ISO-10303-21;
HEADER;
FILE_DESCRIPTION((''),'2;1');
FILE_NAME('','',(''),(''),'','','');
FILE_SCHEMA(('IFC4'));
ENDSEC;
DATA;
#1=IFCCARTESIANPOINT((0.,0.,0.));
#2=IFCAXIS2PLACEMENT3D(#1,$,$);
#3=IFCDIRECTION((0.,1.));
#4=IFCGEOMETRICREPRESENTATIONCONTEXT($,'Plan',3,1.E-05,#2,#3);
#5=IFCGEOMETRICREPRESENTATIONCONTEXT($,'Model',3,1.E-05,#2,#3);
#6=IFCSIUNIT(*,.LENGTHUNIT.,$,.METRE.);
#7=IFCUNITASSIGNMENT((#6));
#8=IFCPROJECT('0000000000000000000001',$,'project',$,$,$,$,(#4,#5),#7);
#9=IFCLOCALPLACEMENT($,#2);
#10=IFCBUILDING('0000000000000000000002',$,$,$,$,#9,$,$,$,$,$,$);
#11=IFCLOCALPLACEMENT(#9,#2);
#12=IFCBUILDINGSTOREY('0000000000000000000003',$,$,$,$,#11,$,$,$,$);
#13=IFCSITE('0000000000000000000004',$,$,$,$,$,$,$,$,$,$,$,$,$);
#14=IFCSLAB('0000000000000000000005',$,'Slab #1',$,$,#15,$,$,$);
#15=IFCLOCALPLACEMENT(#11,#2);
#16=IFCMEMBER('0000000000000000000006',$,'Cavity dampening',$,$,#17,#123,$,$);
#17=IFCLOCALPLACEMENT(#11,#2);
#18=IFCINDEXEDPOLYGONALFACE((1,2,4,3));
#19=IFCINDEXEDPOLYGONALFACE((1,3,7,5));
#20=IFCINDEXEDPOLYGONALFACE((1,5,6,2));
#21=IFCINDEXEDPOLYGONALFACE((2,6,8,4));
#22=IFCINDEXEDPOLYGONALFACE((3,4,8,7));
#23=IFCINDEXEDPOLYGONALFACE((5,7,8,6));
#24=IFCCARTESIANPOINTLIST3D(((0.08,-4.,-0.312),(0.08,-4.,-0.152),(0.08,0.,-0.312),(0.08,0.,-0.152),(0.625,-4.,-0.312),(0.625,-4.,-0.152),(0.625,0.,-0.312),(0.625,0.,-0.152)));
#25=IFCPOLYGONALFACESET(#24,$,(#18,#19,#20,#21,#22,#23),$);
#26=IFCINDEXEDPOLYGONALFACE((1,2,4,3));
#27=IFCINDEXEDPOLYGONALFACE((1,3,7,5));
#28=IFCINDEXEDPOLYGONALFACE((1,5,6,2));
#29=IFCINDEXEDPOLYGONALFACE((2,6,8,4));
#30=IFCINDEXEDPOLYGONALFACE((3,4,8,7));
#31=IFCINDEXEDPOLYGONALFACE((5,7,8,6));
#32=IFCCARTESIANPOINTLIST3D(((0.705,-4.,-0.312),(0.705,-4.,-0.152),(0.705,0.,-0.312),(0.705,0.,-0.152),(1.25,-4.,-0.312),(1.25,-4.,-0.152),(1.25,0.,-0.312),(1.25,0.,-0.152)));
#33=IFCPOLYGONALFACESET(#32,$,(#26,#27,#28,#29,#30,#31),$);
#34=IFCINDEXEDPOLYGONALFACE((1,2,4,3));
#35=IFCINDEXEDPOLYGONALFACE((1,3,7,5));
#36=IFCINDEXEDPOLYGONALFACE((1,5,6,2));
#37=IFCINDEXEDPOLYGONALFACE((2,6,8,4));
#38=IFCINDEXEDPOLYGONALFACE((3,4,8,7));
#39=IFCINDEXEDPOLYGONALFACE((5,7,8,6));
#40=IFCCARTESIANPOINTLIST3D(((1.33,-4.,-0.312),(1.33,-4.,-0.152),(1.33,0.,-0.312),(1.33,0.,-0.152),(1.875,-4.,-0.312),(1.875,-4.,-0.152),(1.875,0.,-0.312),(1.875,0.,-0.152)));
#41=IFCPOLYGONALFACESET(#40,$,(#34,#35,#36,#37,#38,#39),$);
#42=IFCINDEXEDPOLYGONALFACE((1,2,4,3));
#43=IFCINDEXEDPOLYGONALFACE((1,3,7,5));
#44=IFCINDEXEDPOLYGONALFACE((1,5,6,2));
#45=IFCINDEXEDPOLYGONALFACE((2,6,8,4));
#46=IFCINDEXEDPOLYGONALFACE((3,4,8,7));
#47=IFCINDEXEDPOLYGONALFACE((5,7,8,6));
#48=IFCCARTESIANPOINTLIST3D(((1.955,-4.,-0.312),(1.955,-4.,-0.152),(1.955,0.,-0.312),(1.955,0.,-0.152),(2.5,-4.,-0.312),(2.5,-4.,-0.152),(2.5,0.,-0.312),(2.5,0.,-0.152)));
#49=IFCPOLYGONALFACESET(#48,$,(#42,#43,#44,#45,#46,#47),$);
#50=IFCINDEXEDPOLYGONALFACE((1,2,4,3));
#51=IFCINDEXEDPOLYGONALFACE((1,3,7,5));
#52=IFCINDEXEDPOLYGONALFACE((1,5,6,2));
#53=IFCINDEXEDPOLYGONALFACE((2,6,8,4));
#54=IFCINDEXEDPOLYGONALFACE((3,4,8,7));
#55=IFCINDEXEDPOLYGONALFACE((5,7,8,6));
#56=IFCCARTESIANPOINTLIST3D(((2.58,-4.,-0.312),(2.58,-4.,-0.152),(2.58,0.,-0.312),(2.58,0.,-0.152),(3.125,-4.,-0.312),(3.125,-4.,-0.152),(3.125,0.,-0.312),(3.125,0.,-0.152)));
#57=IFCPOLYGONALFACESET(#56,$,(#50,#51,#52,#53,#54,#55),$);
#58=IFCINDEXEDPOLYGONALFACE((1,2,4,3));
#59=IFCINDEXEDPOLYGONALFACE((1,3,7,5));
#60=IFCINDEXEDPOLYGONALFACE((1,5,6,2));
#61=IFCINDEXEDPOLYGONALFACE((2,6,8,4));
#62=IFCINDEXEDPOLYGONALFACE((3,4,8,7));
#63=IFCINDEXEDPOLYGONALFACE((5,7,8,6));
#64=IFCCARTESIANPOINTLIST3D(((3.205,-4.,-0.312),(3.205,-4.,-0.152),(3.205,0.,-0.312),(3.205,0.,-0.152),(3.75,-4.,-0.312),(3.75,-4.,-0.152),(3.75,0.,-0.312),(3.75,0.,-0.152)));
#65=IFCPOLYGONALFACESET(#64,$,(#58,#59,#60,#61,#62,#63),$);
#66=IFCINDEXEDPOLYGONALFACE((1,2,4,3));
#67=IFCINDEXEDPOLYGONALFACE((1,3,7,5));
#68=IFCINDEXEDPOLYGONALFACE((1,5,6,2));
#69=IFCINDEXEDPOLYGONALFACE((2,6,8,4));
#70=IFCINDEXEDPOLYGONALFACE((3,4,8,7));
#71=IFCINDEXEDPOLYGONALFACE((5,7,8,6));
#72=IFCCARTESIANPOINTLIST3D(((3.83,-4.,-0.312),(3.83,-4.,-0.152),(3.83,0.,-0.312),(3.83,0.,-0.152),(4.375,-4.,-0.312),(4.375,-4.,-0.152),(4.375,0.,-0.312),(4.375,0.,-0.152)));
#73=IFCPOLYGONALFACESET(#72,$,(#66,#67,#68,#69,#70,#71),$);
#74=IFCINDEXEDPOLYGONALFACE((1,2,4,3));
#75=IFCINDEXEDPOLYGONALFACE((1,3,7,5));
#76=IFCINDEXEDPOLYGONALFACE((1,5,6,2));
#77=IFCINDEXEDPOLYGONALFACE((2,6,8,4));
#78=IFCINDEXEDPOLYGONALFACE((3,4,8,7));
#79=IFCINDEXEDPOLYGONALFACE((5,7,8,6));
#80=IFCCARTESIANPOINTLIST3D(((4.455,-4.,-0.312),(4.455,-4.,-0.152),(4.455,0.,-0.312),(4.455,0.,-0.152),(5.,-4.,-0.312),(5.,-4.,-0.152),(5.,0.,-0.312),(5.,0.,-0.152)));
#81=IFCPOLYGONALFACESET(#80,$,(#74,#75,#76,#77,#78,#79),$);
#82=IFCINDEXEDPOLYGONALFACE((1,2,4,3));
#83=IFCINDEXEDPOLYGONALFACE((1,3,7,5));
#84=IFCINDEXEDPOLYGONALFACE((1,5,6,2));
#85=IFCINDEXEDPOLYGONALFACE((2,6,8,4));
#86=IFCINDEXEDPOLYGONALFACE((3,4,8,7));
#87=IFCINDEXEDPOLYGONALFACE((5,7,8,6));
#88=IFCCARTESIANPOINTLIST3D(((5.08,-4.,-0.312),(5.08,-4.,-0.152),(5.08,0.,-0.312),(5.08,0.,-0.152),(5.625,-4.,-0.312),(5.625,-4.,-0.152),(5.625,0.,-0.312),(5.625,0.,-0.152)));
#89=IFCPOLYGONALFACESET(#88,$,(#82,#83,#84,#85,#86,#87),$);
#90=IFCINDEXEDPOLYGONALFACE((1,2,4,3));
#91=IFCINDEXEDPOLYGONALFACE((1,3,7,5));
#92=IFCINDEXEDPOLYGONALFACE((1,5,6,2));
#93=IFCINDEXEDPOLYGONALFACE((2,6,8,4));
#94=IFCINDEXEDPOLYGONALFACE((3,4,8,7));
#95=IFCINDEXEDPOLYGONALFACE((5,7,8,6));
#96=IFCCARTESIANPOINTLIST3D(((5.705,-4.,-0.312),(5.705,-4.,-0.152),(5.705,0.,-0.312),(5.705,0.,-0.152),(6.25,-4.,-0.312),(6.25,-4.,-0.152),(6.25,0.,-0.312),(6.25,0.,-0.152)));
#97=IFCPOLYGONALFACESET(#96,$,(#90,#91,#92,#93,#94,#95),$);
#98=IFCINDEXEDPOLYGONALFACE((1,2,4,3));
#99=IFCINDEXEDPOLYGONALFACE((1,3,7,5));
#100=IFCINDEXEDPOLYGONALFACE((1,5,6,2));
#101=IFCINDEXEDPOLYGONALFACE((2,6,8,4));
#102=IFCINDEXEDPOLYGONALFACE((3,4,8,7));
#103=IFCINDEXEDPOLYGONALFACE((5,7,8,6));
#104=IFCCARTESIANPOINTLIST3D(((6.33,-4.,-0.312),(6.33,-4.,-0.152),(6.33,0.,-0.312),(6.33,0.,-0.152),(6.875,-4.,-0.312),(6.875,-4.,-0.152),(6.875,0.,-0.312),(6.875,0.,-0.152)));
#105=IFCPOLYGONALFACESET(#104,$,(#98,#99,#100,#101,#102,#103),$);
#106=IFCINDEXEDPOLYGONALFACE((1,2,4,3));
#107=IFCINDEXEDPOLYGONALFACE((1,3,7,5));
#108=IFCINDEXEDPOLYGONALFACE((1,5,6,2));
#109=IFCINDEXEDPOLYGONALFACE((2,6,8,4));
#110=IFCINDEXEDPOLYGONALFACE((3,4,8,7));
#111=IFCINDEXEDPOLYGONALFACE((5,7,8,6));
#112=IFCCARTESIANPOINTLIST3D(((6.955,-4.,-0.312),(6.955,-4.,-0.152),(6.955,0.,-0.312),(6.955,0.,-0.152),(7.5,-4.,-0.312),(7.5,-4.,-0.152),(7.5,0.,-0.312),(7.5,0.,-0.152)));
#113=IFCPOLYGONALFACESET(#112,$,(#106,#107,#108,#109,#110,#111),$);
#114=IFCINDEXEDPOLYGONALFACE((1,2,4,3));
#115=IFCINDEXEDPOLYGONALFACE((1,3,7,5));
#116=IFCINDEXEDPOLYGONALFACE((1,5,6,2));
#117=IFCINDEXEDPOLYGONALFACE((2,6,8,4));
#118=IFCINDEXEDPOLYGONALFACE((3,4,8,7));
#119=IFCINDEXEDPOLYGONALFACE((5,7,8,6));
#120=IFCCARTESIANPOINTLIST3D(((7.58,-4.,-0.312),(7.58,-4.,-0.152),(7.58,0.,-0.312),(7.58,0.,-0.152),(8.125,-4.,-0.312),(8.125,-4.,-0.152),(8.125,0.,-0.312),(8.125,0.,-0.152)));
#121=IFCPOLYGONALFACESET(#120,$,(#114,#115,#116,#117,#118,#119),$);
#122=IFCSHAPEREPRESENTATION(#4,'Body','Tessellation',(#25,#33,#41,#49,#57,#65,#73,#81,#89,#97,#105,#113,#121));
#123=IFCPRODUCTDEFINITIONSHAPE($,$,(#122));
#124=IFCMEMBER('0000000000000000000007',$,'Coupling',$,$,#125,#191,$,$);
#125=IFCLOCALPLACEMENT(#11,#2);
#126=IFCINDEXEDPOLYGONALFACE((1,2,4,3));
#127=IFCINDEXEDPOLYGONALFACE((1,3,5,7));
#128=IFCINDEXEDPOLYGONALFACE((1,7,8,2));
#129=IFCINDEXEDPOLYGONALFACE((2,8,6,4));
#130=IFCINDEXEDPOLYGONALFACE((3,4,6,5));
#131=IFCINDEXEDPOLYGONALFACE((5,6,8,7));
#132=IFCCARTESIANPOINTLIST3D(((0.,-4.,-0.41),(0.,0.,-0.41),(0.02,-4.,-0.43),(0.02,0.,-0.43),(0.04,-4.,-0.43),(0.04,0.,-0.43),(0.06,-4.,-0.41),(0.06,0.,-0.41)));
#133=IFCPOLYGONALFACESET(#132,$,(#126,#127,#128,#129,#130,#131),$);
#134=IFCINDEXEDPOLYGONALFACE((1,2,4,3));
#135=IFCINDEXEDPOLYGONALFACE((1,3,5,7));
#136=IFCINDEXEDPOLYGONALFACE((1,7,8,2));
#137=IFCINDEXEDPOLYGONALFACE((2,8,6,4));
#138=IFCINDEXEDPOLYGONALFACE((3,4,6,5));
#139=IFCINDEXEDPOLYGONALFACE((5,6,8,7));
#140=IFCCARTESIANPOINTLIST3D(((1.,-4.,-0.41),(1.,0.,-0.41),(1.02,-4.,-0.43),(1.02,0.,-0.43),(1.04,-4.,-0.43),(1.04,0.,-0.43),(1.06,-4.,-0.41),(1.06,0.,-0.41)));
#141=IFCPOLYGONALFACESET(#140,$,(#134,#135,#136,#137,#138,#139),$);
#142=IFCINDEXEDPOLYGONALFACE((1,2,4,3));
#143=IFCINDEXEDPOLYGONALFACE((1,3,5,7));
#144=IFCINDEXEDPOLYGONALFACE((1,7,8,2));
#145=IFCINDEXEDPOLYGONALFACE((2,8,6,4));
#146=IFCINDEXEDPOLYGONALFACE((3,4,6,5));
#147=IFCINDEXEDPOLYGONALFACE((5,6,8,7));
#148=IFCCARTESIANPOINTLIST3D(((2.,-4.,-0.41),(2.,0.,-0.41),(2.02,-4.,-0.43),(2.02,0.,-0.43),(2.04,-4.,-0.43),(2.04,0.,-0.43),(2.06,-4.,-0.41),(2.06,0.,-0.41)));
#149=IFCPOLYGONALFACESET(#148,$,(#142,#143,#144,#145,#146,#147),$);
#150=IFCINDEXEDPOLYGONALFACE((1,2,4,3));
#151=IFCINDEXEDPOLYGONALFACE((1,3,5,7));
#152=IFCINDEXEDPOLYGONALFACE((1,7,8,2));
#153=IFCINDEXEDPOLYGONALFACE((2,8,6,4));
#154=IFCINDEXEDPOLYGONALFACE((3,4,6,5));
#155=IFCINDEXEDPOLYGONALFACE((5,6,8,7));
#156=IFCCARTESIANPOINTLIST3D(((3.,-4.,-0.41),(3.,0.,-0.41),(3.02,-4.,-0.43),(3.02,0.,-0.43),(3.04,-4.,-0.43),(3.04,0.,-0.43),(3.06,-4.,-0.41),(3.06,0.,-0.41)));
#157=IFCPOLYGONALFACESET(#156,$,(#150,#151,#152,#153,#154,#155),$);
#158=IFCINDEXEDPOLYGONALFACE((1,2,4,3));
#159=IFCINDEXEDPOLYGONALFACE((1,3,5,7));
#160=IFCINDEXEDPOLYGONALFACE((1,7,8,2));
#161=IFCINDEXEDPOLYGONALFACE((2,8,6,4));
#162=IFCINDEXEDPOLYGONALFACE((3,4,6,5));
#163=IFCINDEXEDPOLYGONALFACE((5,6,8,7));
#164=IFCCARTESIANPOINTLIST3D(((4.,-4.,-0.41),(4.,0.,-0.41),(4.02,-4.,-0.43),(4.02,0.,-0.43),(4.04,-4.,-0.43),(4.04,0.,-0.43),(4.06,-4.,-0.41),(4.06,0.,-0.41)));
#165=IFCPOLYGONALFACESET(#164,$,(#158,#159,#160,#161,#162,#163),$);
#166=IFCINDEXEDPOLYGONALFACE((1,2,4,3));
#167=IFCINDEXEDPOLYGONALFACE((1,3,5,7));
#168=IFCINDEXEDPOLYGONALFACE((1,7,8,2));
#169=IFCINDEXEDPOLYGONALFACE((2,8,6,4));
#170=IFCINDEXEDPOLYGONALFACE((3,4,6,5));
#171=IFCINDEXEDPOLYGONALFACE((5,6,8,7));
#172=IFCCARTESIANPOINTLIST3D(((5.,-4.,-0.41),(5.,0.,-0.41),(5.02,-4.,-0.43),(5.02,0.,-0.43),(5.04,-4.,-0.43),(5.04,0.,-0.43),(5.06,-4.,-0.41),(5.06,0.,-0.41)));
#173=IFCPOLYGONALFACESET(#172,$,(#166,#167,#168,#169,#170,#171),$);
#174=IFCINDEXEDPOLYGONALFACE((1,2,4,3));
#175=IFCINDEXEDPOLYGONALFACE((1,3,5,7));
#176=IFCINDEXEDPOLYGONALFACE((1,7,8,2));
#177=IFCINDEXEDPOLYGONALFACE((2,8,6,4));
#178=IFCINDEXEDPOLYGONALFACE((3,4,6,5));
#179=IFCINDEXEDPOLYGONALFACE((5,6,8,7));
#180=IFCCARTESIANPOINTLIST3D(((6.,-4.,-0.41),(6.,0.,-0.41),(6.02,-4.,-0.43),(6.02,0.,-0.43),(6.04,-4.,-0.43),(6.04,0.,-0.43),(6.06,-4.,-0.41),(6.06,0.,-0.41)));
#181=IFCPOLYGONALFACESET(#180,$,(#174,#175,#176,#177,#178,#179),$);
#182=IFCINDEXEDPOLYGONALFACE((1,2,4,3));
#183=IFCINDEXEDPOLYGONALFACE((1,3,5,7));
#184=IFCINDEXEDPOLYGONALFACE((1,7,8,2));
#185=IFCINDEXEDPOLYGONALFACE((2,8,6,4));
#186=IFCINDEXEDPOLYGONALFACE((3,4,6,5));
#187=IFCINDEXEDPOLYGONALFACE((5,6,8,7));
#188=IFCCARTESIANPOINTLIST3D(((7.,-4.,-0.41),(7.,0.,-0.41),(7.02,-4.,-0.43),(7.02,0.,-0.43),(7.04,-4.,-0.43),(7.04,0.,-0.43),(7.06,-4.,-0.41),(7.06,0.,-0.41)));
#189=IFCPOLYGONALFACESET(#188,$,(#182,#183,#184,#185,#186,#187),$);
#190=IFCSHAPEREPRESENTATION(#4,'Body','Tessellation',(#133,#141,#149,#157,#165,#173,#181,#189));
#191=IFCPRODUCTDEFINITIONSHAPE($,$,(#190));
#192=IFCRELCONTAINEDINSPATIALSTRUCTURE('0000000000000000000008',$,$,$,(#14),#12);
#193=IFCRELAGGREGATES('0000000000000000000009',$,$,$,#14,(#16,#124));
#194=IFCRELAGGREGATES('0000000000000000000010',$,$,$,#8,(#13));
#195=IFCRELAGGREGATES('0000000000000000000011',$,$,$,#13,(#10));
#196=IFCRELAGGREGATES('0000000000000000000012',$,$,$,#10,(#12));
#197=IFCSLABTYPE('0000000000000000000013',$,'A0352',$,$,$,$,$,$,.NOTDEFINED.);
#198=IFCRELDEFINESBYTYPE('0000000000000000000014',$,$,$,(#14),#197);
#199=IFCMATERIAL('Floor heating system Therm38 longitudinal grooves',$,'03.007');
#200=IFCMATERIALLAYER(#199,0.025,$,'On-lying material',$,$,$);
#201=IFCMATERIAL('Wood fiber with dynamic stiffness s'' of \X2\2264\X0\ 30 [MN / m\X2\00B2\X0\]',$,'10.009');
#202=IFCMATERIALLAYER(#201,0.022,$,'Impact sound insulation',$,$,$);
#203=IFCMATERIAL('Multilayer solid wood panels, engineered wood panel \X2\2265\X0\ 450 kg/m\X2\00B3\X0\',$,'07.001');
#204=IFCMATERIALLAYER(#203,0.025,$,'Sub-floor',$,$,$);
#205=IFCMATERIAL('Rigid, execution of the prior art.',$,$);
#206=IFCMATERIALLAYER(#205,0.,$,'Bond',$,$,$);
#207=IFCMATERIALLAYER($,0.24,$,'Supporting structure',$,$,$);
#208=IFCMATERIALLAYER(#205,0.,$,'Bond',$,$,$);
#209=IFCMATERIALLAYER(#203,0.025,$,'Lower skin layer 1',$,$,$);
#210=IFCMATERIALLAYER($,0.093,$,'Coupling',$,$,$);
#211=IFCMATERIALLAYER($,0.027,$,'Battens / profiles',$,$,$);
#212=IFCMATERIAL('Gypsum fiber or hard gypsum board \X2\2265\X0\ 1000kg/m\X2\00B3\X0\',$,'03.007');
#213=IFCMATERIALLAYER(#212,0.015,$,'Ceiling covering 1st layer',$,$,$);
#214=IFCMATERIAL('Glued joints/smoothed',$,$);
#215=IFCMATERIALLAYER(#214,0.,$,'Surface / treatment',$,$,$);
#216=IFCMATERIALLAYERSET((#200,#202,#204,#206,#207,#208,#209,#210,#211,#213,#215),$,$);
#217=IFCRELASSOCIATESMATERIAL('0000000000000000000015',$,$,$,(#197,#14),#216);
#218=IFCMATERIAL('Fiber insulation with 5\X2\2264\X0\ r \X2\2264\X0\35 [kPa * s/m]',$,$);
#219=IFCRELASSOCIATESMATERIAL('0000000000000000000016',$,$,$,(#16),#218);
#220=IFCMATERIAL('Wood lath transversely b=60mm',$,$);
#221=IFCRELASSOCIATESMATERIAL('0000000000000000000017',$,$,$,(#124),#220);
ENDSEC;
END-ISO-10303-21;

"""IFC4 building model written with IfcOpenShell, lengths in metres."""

from ifc_helpers import new_model, si_unit, direction, frame, frame_2d, origin, place, context, project, spatial, polyline, rectangle, outline, extrude, material, layer, layer_set, type_object, element, aggregate, save


model = new_model("IFC4")

# Units and contexts
plan_context = context("Plan", 3, precision=1e-05, world=origin(), true_north=direction((0.0, 1.0)))
model_context = context("Model", 3, precision=1e-05, world=origin(), true_north=direction((0.0, 1.0)))
ifc_project = project(units=[si_unit("LENGTHUNIT", "METRE")], contexts=[plan_context, model_context])

# Site, building, storey
site = spatial("IfcSite", under=ifc_project)
building_placement = place(None, origin())
building = spatial("IfcBuilding", under=site, at=building_placement)
storey_placement = place(building_placement, origin())
storey = spatial("IfcBuildingStorey", under=building, at=storey_placement)

# Slab, members
ifc_material_1 = material(Name="Floor heating system Therm38 longitudinal grooves", Category="03.007")
ifc_layer_1 = layer(ifc_material_1, 0.025, Name="On-lying material")
ifc_material_2 = material(Name="Wood fiber with dynamic stiffness s' of ≤ 30 [MN / m²]", Category="10.009")
ifc_layer_2 = layer(ifc_material_2, 0.022, Name="Impact sound insulation")
ifc_material_3 = material(Name="Multilayer solid wood panels, engineered wood panel ≥ 450 kg/m³", Category="07.001")
ifc_layer_3 = layer(ifc_material_3, 0.025, Name="Sub-floor")
ifc_material_4 = material(Name="Rigid, execution of the prior art.")
ifc_layer_4 = layer(ifc_material_4, 0.0, Name="Bond")
ifc_layer_5 = layer(None, 0.24, Name="Supporting structure")
ifc_layer_6 = layer(ifc_material_4, 0.0, Name="Bond")
ifc_layer_7 = layer(ifc_material_3, 0.025, Name="Lower skin layer 1")
ifc_layer_8 = layer(None, 0.093, Name="Coupling")
ifc_layer_9 = layer(None, 0.027, Name="Battens / profiles")
ifc_material_5 = material(Name="Gypsum fiber or hard gypsum board ≥ 1000kg/m³", Category="03.007")
ifc_layer_10 = layer(ifc_material_5, 0.015, Name="Ceiling covering 1st layer")
ifc_material_6 = material(Name="Glued joints/smoothed")
ifc_layer_11 = layer(ifc_material_6, 0.0, Name="Surface / treatment")
ifc_layer_set = layer_set([ifc_layer_1, ifc_layer_2, ifc_layer_3, ifc_layer_4, ifc_layer_5, ifc_layer_6, ifc_layer_7, ifc_layer_8, ifc_layer_9, ifc_layer_10, ifc_layer_11])
slab_type = type_object("IfcSlabType", Name="A0352", PredefinedType="NOTDEFINED", material=ifc_layer_set)
slab_placement = place(None, frame((0.0, 0.0, 0.0), z_axis=(0.0, 0.0, -1.0), x_axis=(1.0, 0.0, 0.0)))
slab = element("IfcSlab", 1, at=slab_placement, inside=storey, type_object=slab_type, material=ifc_layer_set, Name="Slab #1")
ifc_material_7 = material(Name="Fiber insulation with 5≤ r ≤35 [kPa * s/m]")
member_1_placement = place(slab_placement, origin())
member_1 = element("IfcMember", 2, at=member_1_placement, material=ifc_material_7, Name="Cavity dampening", context=plan_context, shape_type="SweptSolid", body=[
    extrude(rectangle(XDim=0.545, YDim=0.16, at=frame_2d((0.2725, 0.08), x_axis=(1.0, 0.0))), frame((0.08, 4.0, 0.152), z_axis=(0.0, -1.0, 0.0), x_axis=(1.0, 0.0, 0.0)), (0.0, 0.0, 1.0), 4.0),
    extrude(rectangle(XDim=0.545, YDim=0.16, at=frame_2d((0.2725, 0.08), x_axis=(1.0, 0.0))), frame((0.705, 4.0, 0.152), z_axis=(0.0, -1.0, 0.0), x_axis=(1.0, 0.0, 0.0)), (0.0, 0.0, 1.0), 4.0),
    extrude(rectangle(XDim=0.545, YDim=0.16, at=frame_2d((0.2725, 0.08), x_axis=(1.0, 0.0))), frame((1.33, 4.0, 0.152), z_axis=(0.0, -1.0, 0.0), x_axis=(1.0, 0.0, 0.0)), (0.0, 0.0, 1.0), 4.0),
    extrude(rectangle(XDim=0.545, YDim=0.16, at=frame_2d((0.2725, 0.08), x_axis=(1.0, 0.0))), frame((1.955, 4.0, 0.152), z_axis=(0.0, -1.0, 0.0), x_axis=(1.0, 0.0, 0.0)), (0.0, 0.0, 1.0), 4.0),
    extrude(rectangle(XDim=0.545, YDim=0.16, at=frame_2d((0.2725, 0.08), x_axis=(1.0, 0.0))), frame((2.58, 4.0, 0.152), z_axis=(0.0, -1.0, 0.0), x_axis=(1.0, 0.0, 0.0)), (0.0, 0.0, 1.0), 4.0),
    extrude(rectangle(XDim=0.545, YDim=0.16, at=frame_2d((0.2725, 0.08), x_axis=(1.0, 0.0))), frame((3.205, 4.0, 0.152), z_axis=(0.0, -1.0, 0.0), x_axis=(1.0, 0.0, 0.0)), (0.0, 0.0, 1.0), 4.0),
    extrude(rectangle(XDim=0.545, YDim=0.16, at=frame_2d((0.2725, 0.08), x_axis=(1.0, 0.0))), frame((3.83, 4.0, 0.152), z_axis=(0.0, -1.0, 0.0), x_axis=(1.0, 0.0, 0.0)), (0.0, 0.0, 1.0), 4.0),
    extrude(rectangle(XDim=0.545, YDim=0.16, at=frame_2d((0.2725, 0.08), x_axis=(1.0, 0.0))), frame((4.455, 4.0, 0.152), z_axis=(0.0, -1.0, 0.0), x_axis=(1.0, 0.0, 0.0)), (0.0, 0.0, 1.0), 4.0),
    extrude(rectangle(XDim=0.545, YDim=0.16, at=frame_2d((0.2725, 0.08), x_axis=(1.0, 0.0))), frame((5.08, 4.0, 0.152), z_axis=(0.0, -1.0, 0.0), x_axis=(1.0, 0.0, 0.0)), (0.0, 0.0, 1.0), 4.0),
    extrude(rectangle(XDim=0.545, YDim=0.16, at=frame_2d((0.2725, 0.08), x_axis=(1.0, 0.0))), frame((5.705, 4.0, 0.152), z_axis=(0.0, -1.0, 0.0), x_axis=(1.0, 0.0, 0.0)), (0.0, 0.0, 1.0), 4.0),
    extrude(rectangle(XDim=0.545, YDim=0.16, at=frame_2d((0.2725, 0.08), x_axis=(1.0, 0.0))), frame((6.33, 4.0, 0.152), z_axis=(0.0, -1.0, 0.0), x_axis=(1.0, 0.0, 0.0)), (0.0, 0.0, 1.0), 4.0),
    extrude(rectangle(XDim=0.545, YDim=0.16, at=frame_2d((0.2725, 0.08), x_axis=(1.0, 0.0))), frame((6.955, 4.0, 0.152), z_axis=(0.0, -1.0, 0.0), x_axis=(1.0, 0.0, 0.0)), (0.0, 0.0, 1.0), 4.0),
    extrude(rectangle(XDim=0.545, YDim=0.16, at=frame_2d((0.2725, 0.08), x_axis=(1.0, 0.0))), frame((7.58, 4.0, 0.152), z_axis=(0.0, -1.0, 0.0), x_axis=(1.0, 0.0, 0.0)), (0.0, 0.0, 1.0), 4.0),
])
ifc_material_8 = material(Name="Wood lath transversely b=60mm")
member_2_placement = place(slab_placement, origin())
member_2 = element("IfcMember", 3, at=member_2_placement, material=ifc_material_8, Name="Coupling", context=plan_context, shape_type="SweptSolid", body=[
    extrude(outline(polyline([(0.0, 0.0), (0.06, 0.0), (0.04, 0.02), (0.02, 0.02), (0.0, 0.0)])), frame((0.0, 4.0, 0.41), z_axis=(0.0, -1.0, 0.0), x_axis=(1.0, 0.0, 0.0)), (0.0, 0.0, 1.0), 4.0),
    extrude(outline(polyline([(0.0, 0.0), (0.06, 0.0), (0.04, 0.02), (0.02, 0.02), (0.0, 0.0)])), frame((1.0, 4.0, 0.41), z_axis=(0.0, -1.0, 0.0), x_axis=(1.0, 0.0, 0.0)), (0.0, 0.0, 1.0), 4.0),
    extrude(outline(polyline([(0.0, 0.0), (0.06, 0.0), (0.04, 0.02), (0.02, 0.02), (0.0, 0.0)])), frame((2.0, 4.0, 0.41), z_axis=(0.0, -1.0, 0.0), x_axis=(1.0, 0.0, 0.0)), (0.0, 0.0, 1.0), 4.0),
    extrude(outline(polyline([(0.0, 0.0), (0.06, 0.0), (0.04, 0.02), (0.02, 0.02), (0.0, 0.0)])), frame((3.0, 4.0, 0.41), z_axis=(0.0, -1.0, 0.0), x_axis=(1.0, 0.0, 0.0)), (0.0, 0.0, 1.0), 4.0),
    extrude(outline(polyline([(0.0, 0.0), (0.06, 0.0), (0.04, 0.02), (0.02, 0.02), (0.0, 0.0)])), frame((4.0, 4.0, 0.41), z_axis=(0.0, -1.0, 0.0), x_axis=(1.0, 0.0, 0.0)), (0.0, 0.0, 1.0), 4.0),
    extrude(outline(polyline([(0.0, 0.0), (0.06, 0.0), (0.04, 0.02), (0.02, 0.02), (0.0, 0.0)])), frame((5.0, 4.0, 0.41), z_axis=(0.0, -1.0, 0.0), x_axis=(1.0, 0.0, 0.0)), (0.0, 0.0, 1.0), 4.0),
    extrude(outline(polyline([(0.0, 0.0), (0.06, 0.0), (0.04, 0.02), (0.02, 0.02), (0.0, 0.0)])), frame((6.0, 4.0, 0.41), z_axis=(0.0, -1.0, 0.0), x_axis=(1.0, 0.0, 0.0)), (0.0, 0.0, 1.0), 4.0),
    extrude(outline(polyline([(0.0, 0.0), (0.06, 0.0), (0.04, 0.02), (0.02, 0.02), (0.0, 0.0)])), frame((7.0, 4.0, 0.41), z_axis=(0.0, -1.0, 0.0), x_axis=(1.0, 0.0, 0.0)), (0.0, 0.0, 1.0), 4.0),
])
aggregate(slab, [member_1, member_2])

save(model, "model.ifc")
